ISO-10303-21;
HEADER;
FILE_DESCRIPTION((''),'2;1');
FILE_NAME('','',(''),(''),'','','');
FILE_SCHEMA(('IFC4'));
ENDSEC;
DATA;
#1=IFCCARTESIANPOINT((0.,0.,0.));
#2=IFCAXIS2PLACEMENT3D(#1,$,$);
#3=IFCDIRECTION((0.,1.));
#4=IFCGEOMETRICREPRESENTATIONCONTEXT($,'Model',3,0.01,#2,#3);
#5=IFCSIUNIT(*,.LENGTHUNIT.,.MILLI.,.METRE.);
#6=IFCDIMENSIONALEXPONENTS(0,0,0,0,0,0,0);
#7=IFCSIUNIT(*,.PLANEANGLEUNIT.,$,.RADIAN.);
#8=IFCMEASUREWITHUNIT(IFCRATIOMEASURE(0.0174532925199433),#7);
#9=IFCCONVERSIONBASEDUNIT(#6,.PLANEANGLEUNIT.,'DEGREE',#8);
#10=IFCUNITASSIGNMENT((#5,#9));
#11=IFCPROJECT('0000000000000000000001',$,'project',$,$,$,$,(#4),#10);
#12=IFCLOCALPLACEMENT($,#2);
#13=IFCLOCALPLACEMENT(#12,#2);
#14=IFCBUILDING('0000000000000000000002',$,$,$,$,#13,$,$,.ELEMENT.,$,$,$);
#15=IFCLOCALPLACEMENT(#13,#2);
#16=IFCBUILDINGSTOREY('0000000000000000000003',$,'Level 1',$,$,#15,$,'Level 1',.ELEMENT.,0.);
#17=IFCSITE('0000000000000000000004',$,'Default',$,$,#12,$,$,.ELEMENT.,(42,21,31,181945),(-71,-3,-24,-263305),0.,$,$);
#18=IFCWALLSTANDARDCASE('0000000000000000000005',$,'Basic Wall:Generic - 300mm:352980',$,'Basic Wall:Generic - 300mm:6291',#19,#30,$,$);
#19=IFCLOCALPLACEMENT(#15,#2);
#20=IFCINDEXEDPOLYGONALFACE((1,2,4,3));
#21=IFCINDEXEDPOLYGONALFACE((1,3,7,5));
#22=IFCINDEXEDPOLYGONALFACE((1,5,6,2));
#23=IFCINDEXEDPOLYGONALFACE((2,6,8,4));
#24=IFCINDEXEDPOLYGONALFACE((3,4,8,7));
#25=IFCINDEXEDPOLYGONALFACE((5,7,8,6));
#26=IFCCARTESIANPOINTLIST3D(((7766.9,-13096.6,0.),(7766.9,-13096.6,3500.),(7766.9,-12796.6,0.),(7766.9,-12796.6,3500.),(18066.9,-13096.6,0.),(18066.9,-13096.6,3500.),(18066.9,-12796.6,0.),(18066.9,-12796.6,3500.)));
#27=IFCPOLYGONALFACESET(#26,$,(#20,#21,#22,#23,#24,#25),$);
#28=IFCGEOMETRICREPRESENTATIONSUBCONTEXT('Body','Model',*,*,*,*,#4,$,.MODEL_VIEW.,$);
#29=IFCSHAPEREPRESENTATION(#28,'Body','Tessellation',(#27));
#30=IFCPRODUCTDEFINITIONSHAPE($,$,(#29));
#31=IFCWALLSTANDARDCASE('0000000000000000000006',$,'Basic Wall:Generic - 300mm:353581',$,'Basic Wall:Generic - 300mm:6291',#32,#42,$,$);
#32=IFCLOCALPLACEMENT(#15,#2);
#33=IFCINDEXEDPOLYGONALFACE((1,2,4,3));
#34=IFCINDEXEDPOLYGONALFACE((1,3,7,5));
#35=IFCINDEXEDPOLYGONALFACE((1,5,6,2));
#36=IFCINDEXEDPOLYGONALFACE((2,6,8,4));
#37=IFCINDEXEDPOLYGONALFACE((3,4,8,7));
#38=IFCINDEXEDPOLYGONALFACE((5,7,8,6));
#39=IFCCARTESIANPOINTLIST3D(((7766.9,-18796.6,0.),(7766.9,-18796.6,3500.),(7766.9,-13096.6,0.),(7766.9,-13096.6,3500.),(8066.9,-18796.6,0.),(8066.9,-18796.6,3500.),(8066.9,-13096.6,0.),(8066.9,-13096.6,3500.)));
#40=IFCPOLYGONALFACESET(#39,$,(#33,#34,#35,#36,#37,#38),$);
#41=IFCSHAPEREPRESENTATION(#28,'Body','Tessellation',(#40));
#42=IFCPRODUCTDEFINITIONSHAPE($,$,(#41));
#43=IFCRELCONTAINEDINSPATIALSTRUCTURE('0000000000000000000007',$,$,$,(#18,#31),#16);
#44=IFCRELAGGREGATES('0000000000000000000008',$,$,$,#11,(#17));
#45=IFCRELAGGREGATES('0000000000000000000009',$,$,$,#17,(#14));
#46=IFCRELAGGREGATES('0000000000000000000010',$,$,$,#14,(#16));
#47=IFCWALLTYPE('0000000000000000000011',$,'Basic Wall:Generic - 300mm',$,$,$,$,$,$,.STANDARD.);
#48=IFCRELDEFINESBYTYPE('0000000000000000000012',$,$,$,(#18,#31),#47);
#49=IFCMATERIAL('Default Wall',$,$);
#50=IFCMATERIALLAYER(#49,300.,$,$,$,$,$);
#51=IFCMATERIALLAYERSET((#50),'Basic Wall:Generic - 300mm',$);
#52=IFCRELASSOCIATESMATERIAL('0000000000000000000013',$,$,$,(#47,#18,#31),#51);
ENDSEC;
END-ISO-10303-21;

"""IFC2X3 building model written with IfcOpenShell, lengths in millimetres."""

from ifc_helpers import new_model, entity, si_unit, converted_unit, direction, frame, frame_2d, origin, place, context, subcontext, project, spatial, rectangle, extrude, material, layer, layer_set, layer_usage, type_object, element, save


model = new_model("IFC2X3")

# Units and contexts
model_context = context("Model", 3, precision=0.01, world=origin(), true_north=direction((0.0, 1.0)))
body_context = subcontext(model_context, "Body", "Model", "MODEL_VIEW")
ifc_project = project(units=[si_unit("LENGTHUNIT", "METRE", prefix="MILLI"), converted_unit("PLANEANGLEUNIT", "DEGREE", entity("IfcRatioMeasure", 0.0174532925199433), si_unit("PLANEANGLEUNIT", "RADIAN"), dimensions=[0, 0, 0, 0, 0, 0, 0])], contexts=[model_context])

# Site, building, storey
site_placement = place(None, origin())
site = spatial("IfcSite", under=ifc_project, at=site_placement, Name="Default", CompositionType="ELEMENT", RefLatitude=(42, 21, 31, 181945), RefLongitude=(-71, -3, -24, -263305), RefElevation=0.0)
building_placement = place(site_placement, origin())
building = spatial("IfcBuilding", under=site, at=building_placement, CompositionType="ELEMENT")
storey_placement = place(building_placement, origin())
storey = spatial("IfcBuildingStorey", under=building, at=storey_placement, Name="Level 1", LongName="Level 1", CompositionType="ELEMENT", Elevation=0.0)

# Shared definitions
ifc_material_1 = material(Name="Default Wall")
ifc_layer_1 = layer(ifc_material_1, 300.0)
ifc_layer_set_1 = layer_set([ifc_layer_1], Name="Basic Wall:Generic - 300mm")
wall_type_1 = type_object("IfcWallType", Name="Basic Wall:Generic - 300mm", PredefinedType="STANDARD", material=ifc_layer_set_1)

# Walls
ifc_layer_usage_1 = layer_usage(ifc_layer_set_1, "AXIS2", "NEGATIVE", 150.0)
wall_1_placement = place(storey_placement, frame((7766.9, -12946.6, 0.0)))
element("IfcWallStandardCase", 1, at=wall_1_placement, inside=storey, type_object=wall_type_1, material=ifc_layer_usage_1, Name="Basic Wall:Generic - 300mm:352980", ObjectType="Basic Wall:Generic - 300mm:6291", context=body_context, shape_type="SweptSolid", body=[
    extrude(rectangle(XDim=10300.0, YDim=300.0, at=frame_2d((5150.0, 0.0), x_axis=(-1.0, 0.0))), origin(), (0.0, 0.0, 1.0), 3500.0),
])
ifc_layer_usage_2 = layer_usage(ifc_layer_set_1, "AXIS2", "POSITIVE", -150.0)
wall_2_placement = place(storey_placement, frame((7916.9, -13096.6, 0.0), z_axis=(0.0, 0.0, 1.0), x_axis=(0.0, -1.0, 0.0)))
element("IfcWallStandardCase", 2, at=wall_2_placement, inside=storey, type_object=wall_type_1, material=ifc_layer_usage_2, Name="Basic Wall:Generic - 300mm:353581", ObjectType="Basic Wall:Generic - 300mm:6291", context=body_context, shape_type="SweptSolid", body=[
    extrude(rectangle(XDim=5700.0, YDim=300.0, at=frame_2d((2850.0, 0.0), x_axis=(-1.0, 0.0))), origin(), (0.0, 0.0, 1.0), 3500.0),
])

save(model, "model.ifc")
